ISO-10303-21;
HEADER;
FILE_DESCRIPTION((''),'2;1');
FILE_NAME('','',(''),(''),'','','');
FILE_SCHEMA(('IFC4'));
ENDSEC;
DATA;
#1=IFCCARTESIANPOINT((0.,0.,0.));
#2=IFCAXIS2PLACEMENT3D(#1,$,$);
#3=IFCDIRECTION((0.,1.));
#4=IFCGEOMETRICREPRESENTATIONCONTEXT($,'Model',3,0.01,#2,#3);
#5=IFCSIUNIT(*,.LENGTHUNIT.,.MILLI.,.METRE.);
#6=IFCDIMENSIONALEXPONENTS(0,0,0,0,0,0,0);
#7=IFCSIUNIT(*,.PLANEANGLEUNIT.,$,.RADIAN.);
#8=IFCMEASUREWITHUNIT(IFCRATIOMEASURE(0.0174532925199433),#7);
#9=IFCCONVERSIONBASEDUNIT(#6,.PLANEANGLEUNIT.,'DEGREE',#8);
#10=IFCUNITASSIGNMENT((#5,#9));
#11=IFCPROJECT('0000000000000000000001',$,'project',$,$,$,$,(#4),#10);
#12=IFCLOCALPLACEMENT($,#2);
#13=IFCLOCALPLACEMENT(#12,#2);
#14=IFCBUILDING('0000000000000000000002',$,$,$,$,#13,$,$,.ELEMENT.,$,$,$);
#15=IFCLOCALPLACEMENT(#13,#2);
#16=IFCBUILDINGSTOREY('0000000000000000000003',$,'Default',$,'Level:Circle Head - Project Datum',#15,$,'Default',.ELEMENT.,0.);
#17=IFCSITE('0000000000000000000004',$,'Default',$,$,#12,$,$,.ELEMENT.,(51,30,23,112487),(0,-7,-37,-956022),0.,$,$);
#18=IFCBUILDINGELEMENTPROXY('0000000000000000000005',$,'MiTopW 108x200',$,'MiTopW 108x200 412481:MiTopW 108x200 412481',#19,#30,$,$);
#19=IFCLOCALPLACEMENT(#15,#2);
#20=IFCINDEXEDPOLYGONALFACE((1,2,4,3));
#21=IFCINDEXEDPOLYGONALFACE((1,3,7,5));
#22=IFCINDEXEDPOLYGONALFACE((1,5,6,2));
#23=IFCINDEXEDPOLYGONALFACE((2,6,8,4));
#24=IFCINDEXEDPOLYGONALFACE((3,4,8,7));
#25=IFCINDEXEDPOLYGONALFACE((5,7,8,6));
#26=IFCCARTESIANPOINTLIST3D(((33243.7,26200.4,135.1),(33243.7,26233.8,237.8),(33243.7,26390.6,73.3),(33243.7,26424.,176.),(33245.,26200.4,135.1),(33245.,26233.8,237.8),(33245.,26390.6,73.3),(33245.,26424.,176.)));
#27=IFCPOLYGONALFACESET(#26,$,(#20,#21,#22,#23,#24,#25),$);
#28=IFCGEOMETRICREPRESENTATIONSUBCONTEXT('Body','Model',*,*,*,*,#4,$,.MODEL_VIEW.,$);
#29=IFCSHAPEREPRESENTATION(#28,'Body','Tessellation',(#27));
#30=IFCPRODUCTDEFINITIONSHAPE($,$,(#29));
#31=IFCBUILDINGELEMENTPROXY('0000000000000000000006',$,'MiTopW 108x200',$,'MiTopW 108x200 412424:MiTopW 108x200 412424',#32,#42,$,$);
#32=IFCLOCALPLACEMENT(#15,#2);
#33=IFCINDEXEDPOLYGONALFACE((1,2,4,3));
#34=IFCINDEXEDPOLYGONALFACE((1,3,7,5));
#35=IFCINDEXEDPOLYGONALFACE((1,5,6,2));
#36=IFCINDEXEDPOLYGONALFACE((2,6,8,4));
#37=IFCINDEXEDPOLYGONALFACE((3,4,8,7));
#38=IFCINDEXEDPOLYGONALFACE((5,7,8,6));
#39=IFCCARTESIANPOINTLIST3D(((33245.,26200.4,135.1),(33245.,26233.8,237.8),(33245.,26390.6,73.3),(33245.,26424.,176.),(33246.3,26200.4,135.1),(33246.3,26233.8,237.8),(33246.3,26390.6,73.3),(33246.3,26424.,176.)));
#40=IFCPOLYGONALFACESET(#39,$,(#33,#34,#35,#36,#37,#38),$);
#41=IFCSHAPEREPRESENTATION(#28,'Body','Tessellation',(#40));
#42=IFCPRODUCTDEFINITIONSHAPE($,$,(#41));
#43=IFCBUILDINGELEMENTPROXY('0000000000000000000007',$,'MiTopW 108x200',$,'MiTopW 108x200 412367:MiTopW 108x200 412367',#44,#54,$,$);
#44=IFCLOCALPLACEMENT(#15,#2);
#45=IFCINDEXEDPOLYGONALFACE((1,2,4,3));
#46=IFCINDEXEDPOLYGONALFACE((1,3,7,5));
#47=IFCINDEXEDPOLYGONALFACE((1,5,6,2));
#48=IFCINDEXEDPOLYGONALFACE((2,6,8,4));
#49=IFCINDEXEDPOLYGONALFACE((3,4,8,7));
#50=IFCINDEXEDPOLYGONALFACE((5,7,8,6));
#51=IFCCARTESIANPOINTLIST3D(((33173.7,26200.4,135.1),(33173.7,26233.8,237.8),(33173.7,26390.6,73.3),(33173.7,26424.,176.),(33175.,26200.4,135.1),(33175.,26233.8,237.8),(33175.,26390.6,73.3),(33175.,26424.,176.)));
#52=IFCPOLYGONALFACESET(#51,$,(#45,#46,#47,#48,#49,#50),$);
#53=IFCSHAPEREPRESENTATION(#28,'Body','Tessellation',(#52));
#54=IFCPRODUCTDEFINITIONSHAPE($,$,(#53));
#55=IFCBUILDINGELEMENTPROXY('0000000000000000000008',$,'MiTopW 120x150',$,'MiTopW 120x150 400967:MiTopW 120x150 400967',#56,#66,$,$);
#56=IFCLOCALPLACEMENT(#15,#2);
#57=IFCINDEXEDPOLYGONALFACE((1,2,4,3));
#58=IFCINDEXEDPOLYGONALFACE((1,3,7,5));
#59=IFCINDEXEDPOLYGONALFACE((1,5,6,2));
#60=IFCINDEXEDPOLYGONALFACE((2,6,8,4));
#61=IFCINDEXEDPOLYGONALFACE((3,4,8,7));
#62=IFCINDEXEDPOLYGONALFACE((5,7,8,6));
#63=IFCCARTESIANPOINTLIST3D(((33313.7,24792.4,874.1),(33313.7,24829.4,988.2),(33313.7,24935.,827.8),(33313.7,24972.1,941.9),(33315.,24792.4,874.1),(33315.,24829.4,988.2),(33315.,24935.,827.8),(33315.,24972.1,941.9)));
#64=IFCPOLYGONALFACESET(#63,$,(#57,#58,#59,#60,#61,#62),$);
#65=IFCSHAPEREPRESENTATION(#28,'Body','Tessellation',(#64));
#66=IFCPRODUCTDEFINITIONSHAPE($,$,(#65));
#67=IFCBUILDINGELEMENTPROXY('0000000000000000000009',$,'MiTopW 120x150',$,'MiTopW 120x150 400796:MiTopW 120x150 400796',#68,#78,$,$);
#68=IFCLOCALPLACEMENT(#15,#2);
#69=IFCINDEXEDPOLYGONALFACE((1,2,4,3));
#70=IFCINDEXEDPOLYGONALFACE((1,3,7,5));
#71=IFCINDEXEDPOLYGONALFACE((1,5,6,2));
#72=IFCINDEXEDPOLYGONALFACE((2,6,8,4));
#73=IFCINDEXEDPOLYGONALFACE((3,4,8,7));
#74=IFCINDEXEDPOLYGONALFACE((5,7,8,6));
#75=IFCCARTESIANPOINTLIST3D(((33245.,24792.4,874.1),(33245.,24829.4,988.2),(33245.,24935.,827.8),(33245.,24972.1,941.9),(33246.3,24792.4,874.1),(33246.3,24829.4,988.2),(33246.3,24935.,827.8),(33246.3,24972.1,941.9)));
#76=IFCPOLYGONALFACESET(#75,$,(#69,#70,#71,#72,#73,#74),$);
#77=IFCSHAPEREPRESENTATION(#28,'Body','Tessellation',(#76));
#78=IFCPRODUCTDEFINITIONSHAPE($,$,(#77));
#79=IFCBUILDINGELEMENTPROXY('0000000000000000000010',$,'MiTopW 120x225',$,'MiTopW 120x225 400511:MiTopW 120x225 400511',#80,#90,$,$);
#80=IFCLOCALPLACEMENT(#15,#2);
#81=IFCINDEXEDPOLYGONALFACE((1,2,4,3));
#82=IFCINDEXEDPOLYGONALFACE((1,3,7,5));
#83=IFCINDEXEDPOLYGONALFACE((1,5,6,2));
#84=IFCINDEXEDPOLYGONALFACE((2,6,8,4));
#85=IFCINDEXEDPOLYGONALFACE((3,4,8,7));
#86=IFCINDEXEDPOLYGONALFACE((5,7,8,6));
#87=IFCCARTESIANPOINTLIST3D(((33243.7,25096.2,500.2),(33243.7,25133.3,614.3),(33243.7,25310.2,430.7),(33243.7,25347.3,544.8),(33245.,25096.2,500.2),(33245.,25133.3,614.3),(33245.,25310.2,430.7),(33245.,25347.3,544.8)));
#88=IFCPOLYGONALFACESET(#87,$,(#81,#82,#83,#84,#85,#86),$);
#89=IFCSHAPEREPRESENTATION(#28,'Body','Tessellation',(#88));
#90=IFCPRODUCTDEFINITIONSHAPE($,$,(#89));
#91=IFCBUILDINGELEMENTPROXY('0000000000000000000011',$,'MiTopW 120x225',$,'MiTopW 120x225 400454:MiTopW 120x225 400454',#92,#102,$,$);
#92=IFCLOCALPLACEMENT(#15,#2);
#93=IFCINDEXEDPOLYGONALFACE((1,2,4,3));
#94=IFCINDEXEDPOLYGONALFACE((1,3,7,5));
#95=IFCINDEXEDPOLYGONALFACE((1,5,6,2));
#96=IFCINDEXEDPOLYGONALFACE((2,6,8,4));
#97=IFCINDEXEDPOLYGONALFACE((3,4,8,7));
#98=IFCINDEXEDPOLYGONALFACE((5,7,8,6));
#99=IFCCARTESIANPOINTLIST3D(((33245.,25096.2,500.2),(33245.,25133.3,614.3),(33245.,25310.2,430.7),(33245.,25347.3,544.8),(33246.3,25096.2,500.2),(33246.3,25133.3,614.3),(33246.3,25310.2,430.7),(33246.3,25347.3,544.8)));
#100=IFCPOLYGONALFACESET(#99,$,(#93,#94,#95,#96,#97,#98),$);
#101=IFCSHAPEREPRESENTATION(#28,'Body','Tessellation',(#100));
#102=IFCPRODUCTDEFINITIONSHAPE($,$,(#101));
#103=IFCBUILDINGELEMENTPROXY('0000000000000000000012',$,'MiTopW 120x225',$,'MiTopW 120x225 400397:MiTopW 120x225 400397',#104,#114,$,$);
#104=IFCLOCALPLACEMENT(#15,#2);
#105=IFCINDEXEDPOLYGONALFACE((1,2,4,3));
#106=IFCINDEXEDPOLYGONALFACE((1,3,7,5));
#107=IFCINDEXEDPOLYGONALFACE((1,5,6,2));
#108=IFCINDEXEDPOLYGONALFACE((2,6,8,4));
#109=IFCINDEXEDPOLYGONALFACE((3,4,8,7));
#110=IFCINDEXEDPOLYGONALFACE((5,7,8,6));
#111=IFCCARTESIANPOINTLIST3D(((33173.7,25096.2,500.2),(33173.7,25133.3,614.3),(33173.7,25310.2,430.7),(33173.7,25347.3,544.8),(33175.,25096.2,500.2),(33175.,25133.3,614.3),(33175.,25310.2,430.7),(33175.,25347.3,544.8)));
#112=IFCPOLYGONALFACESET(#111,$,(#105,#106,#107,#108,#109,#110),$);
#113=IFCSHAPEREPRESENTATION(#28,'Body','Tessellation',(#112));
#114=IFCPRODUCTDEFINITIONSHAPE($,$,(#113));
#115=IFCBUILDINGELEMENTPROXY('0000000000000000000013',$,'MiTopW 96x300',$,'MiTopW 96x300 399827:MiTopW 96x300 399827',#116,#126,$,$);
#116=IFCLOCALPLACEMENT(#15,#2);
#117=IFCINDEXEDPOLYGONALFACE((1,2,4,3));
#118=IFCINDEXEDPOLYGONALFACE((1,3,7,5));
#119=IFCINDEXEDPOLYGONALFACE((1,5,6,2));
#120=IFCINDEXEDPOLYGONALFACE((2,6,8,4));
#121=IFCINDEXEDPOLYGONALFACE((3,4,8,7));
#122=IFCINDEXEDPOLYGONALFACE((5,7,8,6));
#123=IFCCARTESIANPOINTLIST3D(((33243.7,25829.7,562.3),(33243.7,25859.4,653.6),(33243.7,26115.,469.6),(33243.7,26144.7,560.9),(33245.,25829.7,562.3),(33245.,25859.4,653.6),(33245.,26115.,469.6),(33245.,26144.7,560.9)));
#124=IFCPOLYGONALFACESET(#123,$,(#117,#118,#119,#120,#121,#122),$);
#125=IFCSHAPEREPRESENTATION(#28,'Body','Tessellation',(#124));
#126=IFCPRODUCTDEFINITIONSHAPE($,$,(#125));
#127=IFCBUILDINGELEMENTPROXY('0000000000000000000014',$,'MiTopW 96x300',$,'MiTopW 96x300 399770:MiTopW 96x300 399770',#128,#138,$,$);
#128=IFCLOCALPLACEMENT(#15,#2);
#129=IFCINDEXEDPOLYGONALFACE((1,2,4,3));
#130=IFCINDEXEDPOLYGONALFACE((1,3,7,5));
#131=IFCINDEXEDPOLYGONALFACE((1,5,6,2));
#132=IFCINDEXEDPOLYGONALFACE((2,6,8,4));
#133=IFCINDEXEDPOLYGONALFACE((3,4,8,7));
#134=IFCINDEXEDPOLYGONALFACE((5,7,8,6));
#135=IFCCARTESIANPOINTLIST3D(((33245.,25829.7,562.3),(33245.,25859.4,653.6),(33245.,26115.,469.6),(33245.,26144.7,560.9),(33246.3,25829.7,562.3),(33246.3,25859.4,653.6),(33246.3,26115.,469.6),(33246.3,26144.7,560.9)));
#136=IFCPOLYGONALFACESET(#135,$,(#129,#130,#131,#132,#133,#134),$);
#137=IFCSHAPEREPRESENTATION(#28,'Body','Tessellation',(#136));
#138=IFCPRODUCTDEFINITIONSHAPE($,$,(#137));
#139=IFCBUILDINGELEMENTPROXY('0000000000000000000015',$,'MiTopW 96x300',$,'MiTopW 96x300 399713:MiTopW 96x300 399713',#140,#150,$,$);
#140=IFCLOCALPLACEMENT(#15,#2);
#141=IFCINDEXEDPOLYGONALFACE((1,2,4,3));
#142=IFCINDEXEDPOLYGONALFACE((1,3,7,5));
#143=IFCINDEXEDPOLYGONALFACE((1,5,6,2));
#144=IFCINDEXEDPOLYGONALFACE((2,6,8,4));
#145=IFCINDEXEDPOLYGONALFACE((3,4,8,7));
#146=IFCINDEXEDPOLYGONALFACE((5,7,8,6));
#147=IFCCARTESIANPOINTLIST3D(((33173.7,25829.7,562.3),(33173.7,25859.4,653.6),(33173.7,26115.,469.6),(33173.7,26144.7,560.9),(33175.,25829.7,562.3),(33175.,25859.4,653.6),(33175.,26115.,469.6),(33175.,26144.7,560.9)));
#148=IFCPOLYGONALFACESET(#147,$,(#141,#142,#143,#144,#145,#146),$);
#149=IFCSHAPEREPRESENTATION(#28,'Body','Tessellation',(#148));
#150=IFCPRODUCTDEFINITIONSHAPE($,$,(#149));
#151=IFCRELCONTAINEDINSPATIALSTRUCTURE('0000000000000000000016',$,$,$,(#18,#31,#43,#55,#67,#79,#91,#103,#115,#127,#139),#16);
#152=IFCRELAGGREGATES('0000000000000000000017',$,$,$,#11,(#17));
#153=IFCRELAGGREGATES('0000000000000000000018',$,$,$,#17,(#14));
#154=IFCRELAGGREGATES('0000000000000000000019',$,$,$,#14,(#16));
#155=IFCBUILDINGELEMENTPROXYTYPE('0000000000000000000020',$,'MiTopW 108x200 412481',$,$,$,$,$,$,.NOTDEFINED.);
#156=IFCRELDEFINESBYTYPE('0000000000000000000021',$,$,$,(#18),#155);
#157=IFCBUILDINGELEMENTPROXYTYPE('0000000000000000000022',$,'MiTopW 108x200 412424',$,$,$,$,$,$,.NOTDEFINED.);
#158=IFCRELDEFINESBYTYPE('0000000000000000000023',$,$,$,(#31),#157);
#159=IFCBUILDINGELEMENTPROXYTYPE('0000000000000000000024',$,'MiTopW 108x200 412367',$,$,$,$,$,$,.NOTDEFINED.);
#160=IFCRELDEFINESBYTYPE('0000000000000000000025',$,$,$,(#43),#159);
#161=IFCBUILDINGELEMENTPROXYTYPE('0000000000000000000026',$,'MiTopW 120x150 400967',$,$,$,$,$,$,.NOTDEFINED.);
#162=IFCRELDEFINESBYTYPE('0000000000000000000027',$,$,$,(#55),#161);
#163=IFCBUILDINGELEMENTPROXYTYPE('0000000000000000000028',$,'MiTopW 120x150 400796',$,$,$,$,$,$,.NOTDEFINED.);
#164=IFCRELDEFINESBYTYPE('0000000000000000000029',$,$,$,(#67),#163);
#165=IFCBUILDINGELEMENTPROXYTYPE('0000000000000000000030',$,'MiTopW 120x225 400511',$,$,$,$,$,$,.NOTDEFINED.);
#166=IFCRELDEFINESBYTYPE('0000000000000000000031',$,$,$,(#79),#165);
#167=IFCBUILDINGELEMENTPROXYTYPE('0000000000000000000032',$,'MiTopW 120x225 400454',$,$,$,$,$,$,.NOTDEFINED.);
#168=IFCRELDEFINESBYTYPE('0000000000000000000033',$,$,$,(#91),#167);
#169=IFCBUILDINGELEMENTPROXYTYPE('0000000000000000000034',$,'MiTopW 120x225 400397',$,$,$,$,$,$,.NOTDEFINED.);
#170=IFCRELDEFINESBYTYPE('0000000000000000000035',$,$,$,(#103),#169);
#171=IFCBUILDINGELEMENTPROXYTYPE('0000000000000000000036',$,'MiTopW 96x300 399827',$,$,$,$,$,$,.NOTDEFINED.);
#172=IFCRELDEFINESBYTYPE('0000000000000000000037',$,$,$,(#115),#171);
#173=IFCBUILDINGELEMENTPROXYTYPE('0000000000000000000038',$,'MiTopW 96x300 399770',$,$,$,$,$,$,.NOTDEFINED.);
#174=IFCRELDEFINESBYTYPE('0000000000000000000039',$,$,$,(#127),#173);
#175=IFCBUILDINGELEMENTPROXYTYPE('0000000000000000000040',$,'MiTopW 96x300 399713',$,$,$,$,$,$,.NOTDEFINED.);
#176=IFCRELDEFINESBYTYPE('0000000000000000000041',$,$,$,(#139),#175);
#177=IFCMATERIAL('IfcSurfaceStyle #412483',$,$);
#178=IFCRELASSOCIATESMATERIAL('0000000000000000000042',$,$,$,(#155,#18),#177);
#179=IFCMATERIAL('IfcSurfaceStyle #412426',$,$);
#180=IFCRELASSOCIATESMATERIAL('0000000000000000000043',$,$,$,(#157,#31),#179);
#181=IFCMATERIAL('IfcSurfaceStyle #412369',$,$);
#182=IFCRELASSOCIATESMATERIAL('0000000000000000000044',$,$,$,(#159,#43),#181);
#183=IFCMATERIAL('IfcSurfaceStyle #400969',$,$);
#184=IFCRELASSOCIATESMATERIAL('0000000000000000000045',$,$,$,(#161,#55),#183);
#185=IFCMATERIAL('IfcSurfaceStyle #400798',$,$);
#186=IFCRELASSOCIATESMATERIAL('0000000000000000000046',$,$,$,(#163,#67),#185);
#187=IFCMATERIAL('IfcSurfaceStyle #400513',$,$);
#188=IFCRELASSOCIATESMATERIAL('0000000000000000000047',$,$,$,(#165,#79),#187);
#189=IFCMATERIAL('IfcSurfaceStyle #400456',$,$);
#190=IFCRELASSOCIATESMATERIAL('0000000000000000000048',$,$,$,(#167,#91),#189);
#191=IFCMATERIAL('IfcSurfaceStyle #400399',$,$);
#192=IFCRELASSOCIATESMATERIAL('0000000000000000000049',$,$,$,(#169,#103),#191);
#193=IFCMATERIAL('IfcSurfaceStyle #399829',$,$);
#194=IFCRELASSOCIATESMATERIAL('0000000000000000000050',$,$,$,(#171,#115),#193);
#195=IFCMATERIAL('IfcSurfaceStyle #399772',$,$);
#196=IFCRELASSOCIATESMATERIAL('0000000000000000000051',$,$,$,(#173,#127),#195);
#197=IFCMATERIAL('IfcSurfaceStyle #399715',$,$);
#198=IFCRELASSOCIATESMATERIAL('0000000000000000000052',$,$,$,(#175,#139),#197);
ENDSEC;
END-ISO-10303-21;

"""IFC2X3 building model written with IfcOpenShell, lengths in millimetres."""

from ifc_helpers import new_model, entity, si_unit, converted_unit, direction, frame, origin, place, context, subcontext, project, spatial, polyline, outline, extrude, source, transform, mapped, material, type_object, type_shapes, element, save


model = new_model("IFC2X3")

# Units and contexts
model_context = context("Model", 3, precision=0.01, world=origin(), true_north=direction((0.0, 1.0)))
body_context = subcontext(model_context, "Body", "Model", "MODEL_VIEW")
ifc_project = project(units=[si_unit("LENGTHUNIT", "METRE", prefix="MILLI"), converted_unit("PLANEANGLEUNIT", "DEGREE", entity("IfcRatioMeasure", 0.0174532925199433), si_unit("PLANEANGLEUNIT", "RADIAN"), dimensions=[0, 0, 0, 0, 0, 0, 0])], contexts=[model_context])

# Site, building, storey
site_placement = place(None, origin())
site = spatial("IfcSite", under=ifc_project, at=site_placement, Name="Default", CompositionType="ELEMENT", RefLatitude=(51, 30, 23, 112487), RefLongitude=(0, -7, -37, -956022), RefElevation=0.0)
building_placement = place(site_placement, origin())
building = spatial("IfcBuilding", under=site, at=building_placement, CompositionType="ELEMENT")
storey_placement = place(building_placement, origin())
storey = spatial("IfcBuildingStorey", under=building, at=storey_placement, Name="Default", ObjectType="Level:Circle Head - Project Datum", LongName="Default", CompositionType="ELEMENT", Elevation=0.0)

# Building element proxies
ifc_material_1 = material(Name="IfcSurfaceStyle #412483")
building_element_proxy_type_1 = type_object("IfcBuildingElementProxyType", Name="MiTopW 108x200 412481", PredefinedType="NOTDEFINED", material=ifc_material_1)
shared_shape_1 = source(origin(), body_context, "Body", "SweptSolid", [
    extrude(outline(polyline([(-100.0, -54.0), (100.0, -54.0), (100.0, 54.0), (-100.0, 54.0), (-100.0, -54.0)])), frame((100.0, 54.0, 0.0), z_axis=(0.0, 0.0, 1.0), x_axis=(-1.0, 0.0, 0.0)), (0.0, 0.0, 1.0), 1.3),
])
type_shapes(building_element_proxy_type_1, [shared_shape_1])
proxy_1_placement = place(building_placement, frame((33245.0, 26390.6, 73.3), z_axis=(-1.0, 0.0, 0.0), x_axis=(0.0, -0.951057, 0.309017)))
element("IfcBuildingElementProxy", 1, at=proxy_1_placement, inside=storey, type_object=building_element_proxy_type_1, material=ifc_material_1, Name="MiTopW 108x200", ObjectType="MiTopW 108x200 412481:MiTopW 108x200 412481", context=body_context, shape_type="MappedRepresentation", body=[
    mapped(shared_shape_1, transform((0.0, 0.0, 0.0), scale=1.0)),
])
ifc_material_2 = material(Name="IfcSurfaceStyle #412426")
building_element_proxy_type_2 = type_object("IfcBuildingElementProxyType", Name="MiTopW 108x200 412424", PredefinedType="NOTDEFINED", material=ifc_material_2)
shared_shape_2 = source(origin(), body_context, "Body", "SweptSolid", [
    extrude(outline(polyline([(-100.0, -54.0), (100.0, -54.0), (100.0, 54.0), (-100.0, 54.0), (-100.0, -54.0)])), frame((100.0, 54.0, 0.0), z_axis=(0.0, 0.0, 1.0), x_axis=(-1.0, 0.0, 0.0)), (0.0, 0.0, 1.0), 1.3),
])
type_shapes(building_element_proxy_type_2, [shared_shape_2])
proxy_2_placement = place(building_placement, frame((33246.3, 26390.6, 73.3), z_axis=(-1.0, 0.0, 0.0), x_axis=(0.0, -0.951057, 0.309017)))
element("IfcBuildingElementProxy", 2, at=proxy_2_placement, inside=storey, type_object=building_element_proxy_type_2, material=ifc_material_2, Name="MiTopW 108x200", ObjectType="MiTopW 108x200 412424:MiTopW 108x200 412424", context=body_context, shape_type="MappedRepresentation", body=[
    mapped(shared_shape_2, transform((0.0, 0.0, 0.0), scale=1.0)),
])
ifc_material_3 = material(Name="IfcSurfaceStyle #412369")
building_element_proxy_type_3 = type_object("IfcBuildingElementProxyType", Name="MiTopW 108x200 412367", PredefinedType="NOTDEFINED", material=ifc_material_3)
shared_shape_3 = source(origin(), body_context, "Body", "SweptSolid", [
    extrude(outline(polyline([(-100.0, -54.0), (100.0, -54.0), (100.0, 54.0), (-100.0, 54.0), (-100.0, -54.0)])), frame((100.0, 54.0, 0.0), z_axis=(0.0, 0.0, 1.0), x_axis=(-1.0, 0.0, 0.0)), (0.0, 0.0, 1.0), 1.3),
])
type_shapes(building_element_proxy_type_3, [shared_shape_3])
proxy_3_placement = place(building_placement, frame((33175.0, 26390.6, 73.3), z_axis=(-1.0, 0.0, 0.0), x_axis=(0.0, -0.951057, 0.309017)))
element("IfcBuildingElementProxy", 3, at=proxy_3_placement, inside=storey, type_object=building_element_proxy_type_3, material=ifc_material_3, Name="MiTopW 108x200", ObjectType="MiTopW 108x200 412367:MiTopW 108x200 412367", context=body_context, shape_type="MappedRepresentation", body=[
    mapped(shared_shape_3, transform((0.0, 0.0, 0.0), scale=1.0)),
])
ifc_material_4 = material(Name="IfcSurfaceStyle #400969")
building_element_proxy_type_4 = type_object("IfcBuildingElementProxyType", Name="MiTopW 120x150 400967", PredefinedType="NOTDEFINED", material=ifc_material_4)
shared_shape_4 = source(origin(), body_context, "Body", "SweptSolid", [
    extrude(outline(polyline([(-75.0, -60.0), (75.0, -60.0), (75.0, 60.0), (-75.0, 60.0), (-75.0, -60.0)])), frame((75.0, 60.0, 0.0), z_axis=(0.0, 0.0, 1.0), x_axis=(-1.0, 0.0, 0.0)), (0.0, 0.0, 1.0), 1.3),
])
type_shapes(building_element_proxy_type_4, [shared_shape_4])
proxy_4_placement = place(building_placement, frame((33315.0, 24935.0, 827.8), z_axis=(-1.0, 0.0, 0.0), x_axis=(0.0, -0.951057, 0.309017)))
element("IfcBuildingElementProxy", 4, at=proxy_4_placement, inside=storey, type_object=building_element_proxy_type_4, material=ifc_material_4, Name="MiTopW 120x150", ObjectType="MiTopW 120x150 400967:MiTopW 120x150 400967", context=body_context, shape_type="MappedRepresentation", body=[
    mapped(shared_shape_4, transform((0.0, 0.0, 0.0), scale=1.0)),
])
ifc_material_5 = material(Name="IfcSurfaceStyle #400798")
building_element_proxy_type_5 = type_object("IfcBuildingElementProxyType", Name="MiTopW 120x150 400796", PredefinedType="NOTDEFINED", material=ifc_material_5)
shared_shape_5 = source(origin(), body_context, "Body", "SweptSolid", [
    extrude(outline(polyline([(-75.0, -60.0), (75.0, -60.0), (75.0, 60.0), (-75.0, 60.0), (-75.0, -60.0)])), frame((75.0, 60.0, 0.0), z_axis=(0.0, 0.0, 1.0), x_axis=(-1.0, 0.0, 0.0)), (0.0, 0.0, 1.0), 1.3),
])
type_shapes(building_element_proxy_type_5, [shared_shape_5])
proxy_5_placement = place(building_placement, frame((33246.3, 24935.0, 827.8), z_axis=(-1.0, 0.0, 0.0), x_axis=(0.0, -0.951057, 0.309017)))
element("IfcBuildingElementProxy", 5, at=proxy_5_placement, inside=storey, type_object=building_element_proxy_type_5, material=ifc_material_5, Name="MiTopW 120x150", ObjectType="MiTopW 120x150 400796:MiTopW 120x150 400796", context=body_context, shape_type="MappedRepresentation", body=[
    mapped(shared_shape_5, transform((0.0, 0.0, 0.0), scale=1.0)),
])
ifc_material_6 = material(Name="IfcSurfaceStyle #400513")
building_element_proxy_type_6 = type_object("IfcBuildingElementProxyType", Name="MiTopW 120x225 400511", PredefinedType="NOTDEFINED", material=ifc_material_6)
shared_shape_6 = source(origin(), body_context, "Body", "SweptSolid", [
    extrude(outline(polyline([(-112.5, -60.0), (112.5, -60.0), (112.5, 60.0), (-112.5, 60.0), (-112.5, -60.0)])), frame((112.5, 60.0, 0.0), z_axis=(0.0, 0.0, 1.0), x_axis=(-1.0, 0.0, 0.0)), (0.0, 0.0, 1.0), 1.3),
])
type_shapes(building_element_proxy_type_6, [shared_shape_6])
proxy_6_placement = place(building_placement, frame((33245.0, 25310.2, 430.7), z_axis=(-1.0, 0.0, 0.0), x_axis=(0.0, -0.951057, 0.309017)))
element("IfcBuildingElementProxy", 6, at=proxy_6_placement, inside=storey, type_object=building_element_proxy_type_6, material=ifc_material_6, Name="MiTopW 120x225", ObjectType="MiTopW 120x225 400511:MiTopW 120x225 400511", context=body_context, shape_type="MappedRepresentation", body=[
    mapped(shared_shape_6, transform((0.0, 0.0, 0.0), scale=1.0)),
])
ifc_material_7 = material(Name="IfcSurfaceStyle #400456")
building_element_proxy_type_7 = type_object("IfcBuildingElementProxyType", Name="MiTopW 120x225 400454", PredefinedType="NOTDEFINED", material=ifc_material_7)
shared_shape_7 = source(origin(), body_context, "Body", "SweptSolid", [
    extrude(outline(polyline([(-112.5, -60.0), (112.5, -60.0), (112.5, 60.0), (-112.5, 60.0), (-112.5, -60.0)])), frame((112.5, 60.0, 0.0), z_axis=(0.0, 0.0, 1.0), x_axis=(-1.0, 0.0, 0.0)), (0.0, 0.0, 1.0), 1.3),
])
type_shapes(building_element_proxy_type_7, [shared_shape_7])
proxy_7_placement = place(building_placement, frame((33246.3, 25310.2, 430.7), z_axis=(-1.0, 0.0, 0.0), x_axis=(0.0, -0.951057, 0.309017)))
element("IfcBuildingElementProxy", 7, at=proxy_7_placement, inside=storey, type_object=building_element_proxy_type_7, material=ifc_material_7, Name="MiTopW 120x225", ObjectType="MiTopW 120x225 400454:MiTopW 120x225 400454", context=body_context, shape_type="MappedRepresentation", body=[
    mapped(shared_shape_7, transform((0.0, 0.0, 0.0), scale=1.0)),
])
ifc_material_8 = material(Name="IfcSurfaceStyle #400399")
building_element_proxy_type_8 = type_object("IfcBuildingElementProxyType", Name="MiTopW 120x225 400397", PredefinedType="NOTDEFINED", material=ifc_material_8)
shared_shape_8 = source(origin(), body_context, "Body", "SweptSolid", [
    extrude(outline(polyline([(-112.5, -60.0), (112.5, -60.0), (112.5, 60.0), (-112.5, 60.0), (-112.5, -60.0)])), frame((112.5, 60.0, 0.0), z_axis=(0.0, 0.0, 1.0), x_axis=(-1.0, 0.0, 0.0)), (0.0, 0.0, 1.0), 1.3),
])
type_shapes(building_element_proxy_type_8, [shared_shape_8])
proxy_8_placement = place(building_placement, frame((33175.0, 25310.2, 430.7), z_axis=(-1.0, 0.0, 0.0), x_axis=(0.0, -0.951057, 0.309017)))
element("IfcBuildingElementProxy", 8, at=proxy_8_placement, inside=storey, type_object=building_element_proxy_type_8, material=ifc_material_8, Name="MiTopW 120x225", ObjectType="MiTopW 120x225 400397:MiTopW 120x225 400397", context=body_context, shape_type="MappedRepresentation", body=[
    mapped(shared_shape_8, transform((0.0, 0.0, 0.0), scale=1.0)),
])
ifc_material_9 = material(Name="IfcSurfaceStyle #399829")
building_element_proxy_type_9 = type_object("IfcBuildingElementProxyType", Name="MiTopW 96x300 399827", PredefinedType="NOTDEFINED", material=ifc_material_9)
shared_shape_9 = source(origin(), body_context, "Body", "SweptSolid", [
    extrude(outline(polyline([(-150.0, -48.0), (150.0, -48.0), (150.0, 48.0), (-150.0, 48.0), (-150.0, -48.0)])), frame((150.0, 48.0, 0.0), z_axis=(0.0, 0.0, 1.0), x_axis=(-1.0, 0.0, 0.0)), (0.0, 0.0, 1.0), 1.3),
])
type_shapes(building_element_proxy_type_9, [shared_shape_9])
proxy_9_placement = place(building_placement, frame((33245.0, 26115.0, 469.6), z_axis=(-1.0, 0.0, 0.0), x_axis=(0.0, -0.951057, 0.309017)))
element("IfcBuildingElementProxy", 9, at=proxy_9_placement, inside=storey, type_object=building_element_proxy_type_9, material=ifc_material_9, Name="MiTopW 96x300", ObjectType="MiTopW 96x300 399827:MiTopW 96x300 399827", context=body_context, shape_type="MappedRepresentation", body=[
    mapped(shared_shape_9, transform((0.0, 0.0, 0.0), scale=1.0)),
])
ifc_material_10 = material(Name="IfcSurfaceStyle #399772")
building_element_proxy_type_10 = type_object("IfcBuildingElementProxyType", Name="MiTopW 96x300 399770", PredefinedType="NOTDEFINED", material=ifc_material_10)
shared_shape_10 = source(origin(), body_context, "Body", "SweptSolid", [
    extrude(outline(polyline([(-150.0, -48.0), (150.0, -48.0), (150.0, 48.0), (-150.0, 48.0), (-150.0, -48.0)])), frame((150.0, 48.0, 0.0), z_axis=(0.0, 0.0, 1.0), x_axis=(-1.0, 0.0, 0.0)), (0.0, 0.0, 1.0), 1.3),
])
type_shapes(building_element_proxy_type_10, [shared_shape_10])
proxy_10_placement = place(building_placement, frame((33246.3, 26115.0, 469.6), z_axis=(-1.0, 0.0, 0.0), x_axis=(0.0, -0.951057, 0.309017)))
element("IfcBuildingElementProxy", 10, at=proxy_10_placement, inside=storey, type_object=building_element_proxy_type_10, material=ifc_material_10, Name="MiTopW 96x300", ObjectType="MiTopW 96x300 399770:MiTopW 96x300 399770", context=body_context, shape_type="MappedRepresentation", body=[
    mapped(shared_shape_10, transform((0.0, 0.0, 0.0), scale=1.0)),
])
ifc_material_11 = material(Name="IfcSurfaceStyle #399715")
building_element_proxy_type_11 = type_object("IfcBuildingElementProxyType", Name="MiTopW 96x300 399713", PredefinedType="NOTDEFINED", material=ifc_material_11)
shared_shape_11 = source(origin(), body_context, "Body", "SweptSolid", [
    extrude(outline(polyline([(-150.0, -48.0), (150.0, -48.0), (150.0, 48.0), (-150.0, 48.0), (-150.0, -48.0)])), frame((150.0, 48.0, 0.0), z_axis=(0.0, 0.0, 1.0), x_axis=(-1.0, 0.0, 0.0)), (0.0, 0.0, 1.0), 1.3),
])
type_shapes(building_element_proxy_type_11, [shared_shape_11])
proxy_11_placement = place(building_placement, frame((33175.0, 26115.0, 469.6), z_axis=(-1.0, 0.0, 0.0), x_axis=(0.0, -0.951057, 0.309017)))
element("IfcBuildingElementProxy", 11, at=proxy_11_placement, inside=storey, type_object=building_element_proxy_type_11, material=ifc_material_11, Name="MiTopW 96x300", ObjectType="MiTopW 96x300 399713:MiTopW 96x300 399713", context=body_context, shape_type="MappedRepresentation", body=[
    mapped(shared_shape_11, transform((0.0, 0.0, 0.0), scale=1.0)),
])

save(model, "model.ifc")
